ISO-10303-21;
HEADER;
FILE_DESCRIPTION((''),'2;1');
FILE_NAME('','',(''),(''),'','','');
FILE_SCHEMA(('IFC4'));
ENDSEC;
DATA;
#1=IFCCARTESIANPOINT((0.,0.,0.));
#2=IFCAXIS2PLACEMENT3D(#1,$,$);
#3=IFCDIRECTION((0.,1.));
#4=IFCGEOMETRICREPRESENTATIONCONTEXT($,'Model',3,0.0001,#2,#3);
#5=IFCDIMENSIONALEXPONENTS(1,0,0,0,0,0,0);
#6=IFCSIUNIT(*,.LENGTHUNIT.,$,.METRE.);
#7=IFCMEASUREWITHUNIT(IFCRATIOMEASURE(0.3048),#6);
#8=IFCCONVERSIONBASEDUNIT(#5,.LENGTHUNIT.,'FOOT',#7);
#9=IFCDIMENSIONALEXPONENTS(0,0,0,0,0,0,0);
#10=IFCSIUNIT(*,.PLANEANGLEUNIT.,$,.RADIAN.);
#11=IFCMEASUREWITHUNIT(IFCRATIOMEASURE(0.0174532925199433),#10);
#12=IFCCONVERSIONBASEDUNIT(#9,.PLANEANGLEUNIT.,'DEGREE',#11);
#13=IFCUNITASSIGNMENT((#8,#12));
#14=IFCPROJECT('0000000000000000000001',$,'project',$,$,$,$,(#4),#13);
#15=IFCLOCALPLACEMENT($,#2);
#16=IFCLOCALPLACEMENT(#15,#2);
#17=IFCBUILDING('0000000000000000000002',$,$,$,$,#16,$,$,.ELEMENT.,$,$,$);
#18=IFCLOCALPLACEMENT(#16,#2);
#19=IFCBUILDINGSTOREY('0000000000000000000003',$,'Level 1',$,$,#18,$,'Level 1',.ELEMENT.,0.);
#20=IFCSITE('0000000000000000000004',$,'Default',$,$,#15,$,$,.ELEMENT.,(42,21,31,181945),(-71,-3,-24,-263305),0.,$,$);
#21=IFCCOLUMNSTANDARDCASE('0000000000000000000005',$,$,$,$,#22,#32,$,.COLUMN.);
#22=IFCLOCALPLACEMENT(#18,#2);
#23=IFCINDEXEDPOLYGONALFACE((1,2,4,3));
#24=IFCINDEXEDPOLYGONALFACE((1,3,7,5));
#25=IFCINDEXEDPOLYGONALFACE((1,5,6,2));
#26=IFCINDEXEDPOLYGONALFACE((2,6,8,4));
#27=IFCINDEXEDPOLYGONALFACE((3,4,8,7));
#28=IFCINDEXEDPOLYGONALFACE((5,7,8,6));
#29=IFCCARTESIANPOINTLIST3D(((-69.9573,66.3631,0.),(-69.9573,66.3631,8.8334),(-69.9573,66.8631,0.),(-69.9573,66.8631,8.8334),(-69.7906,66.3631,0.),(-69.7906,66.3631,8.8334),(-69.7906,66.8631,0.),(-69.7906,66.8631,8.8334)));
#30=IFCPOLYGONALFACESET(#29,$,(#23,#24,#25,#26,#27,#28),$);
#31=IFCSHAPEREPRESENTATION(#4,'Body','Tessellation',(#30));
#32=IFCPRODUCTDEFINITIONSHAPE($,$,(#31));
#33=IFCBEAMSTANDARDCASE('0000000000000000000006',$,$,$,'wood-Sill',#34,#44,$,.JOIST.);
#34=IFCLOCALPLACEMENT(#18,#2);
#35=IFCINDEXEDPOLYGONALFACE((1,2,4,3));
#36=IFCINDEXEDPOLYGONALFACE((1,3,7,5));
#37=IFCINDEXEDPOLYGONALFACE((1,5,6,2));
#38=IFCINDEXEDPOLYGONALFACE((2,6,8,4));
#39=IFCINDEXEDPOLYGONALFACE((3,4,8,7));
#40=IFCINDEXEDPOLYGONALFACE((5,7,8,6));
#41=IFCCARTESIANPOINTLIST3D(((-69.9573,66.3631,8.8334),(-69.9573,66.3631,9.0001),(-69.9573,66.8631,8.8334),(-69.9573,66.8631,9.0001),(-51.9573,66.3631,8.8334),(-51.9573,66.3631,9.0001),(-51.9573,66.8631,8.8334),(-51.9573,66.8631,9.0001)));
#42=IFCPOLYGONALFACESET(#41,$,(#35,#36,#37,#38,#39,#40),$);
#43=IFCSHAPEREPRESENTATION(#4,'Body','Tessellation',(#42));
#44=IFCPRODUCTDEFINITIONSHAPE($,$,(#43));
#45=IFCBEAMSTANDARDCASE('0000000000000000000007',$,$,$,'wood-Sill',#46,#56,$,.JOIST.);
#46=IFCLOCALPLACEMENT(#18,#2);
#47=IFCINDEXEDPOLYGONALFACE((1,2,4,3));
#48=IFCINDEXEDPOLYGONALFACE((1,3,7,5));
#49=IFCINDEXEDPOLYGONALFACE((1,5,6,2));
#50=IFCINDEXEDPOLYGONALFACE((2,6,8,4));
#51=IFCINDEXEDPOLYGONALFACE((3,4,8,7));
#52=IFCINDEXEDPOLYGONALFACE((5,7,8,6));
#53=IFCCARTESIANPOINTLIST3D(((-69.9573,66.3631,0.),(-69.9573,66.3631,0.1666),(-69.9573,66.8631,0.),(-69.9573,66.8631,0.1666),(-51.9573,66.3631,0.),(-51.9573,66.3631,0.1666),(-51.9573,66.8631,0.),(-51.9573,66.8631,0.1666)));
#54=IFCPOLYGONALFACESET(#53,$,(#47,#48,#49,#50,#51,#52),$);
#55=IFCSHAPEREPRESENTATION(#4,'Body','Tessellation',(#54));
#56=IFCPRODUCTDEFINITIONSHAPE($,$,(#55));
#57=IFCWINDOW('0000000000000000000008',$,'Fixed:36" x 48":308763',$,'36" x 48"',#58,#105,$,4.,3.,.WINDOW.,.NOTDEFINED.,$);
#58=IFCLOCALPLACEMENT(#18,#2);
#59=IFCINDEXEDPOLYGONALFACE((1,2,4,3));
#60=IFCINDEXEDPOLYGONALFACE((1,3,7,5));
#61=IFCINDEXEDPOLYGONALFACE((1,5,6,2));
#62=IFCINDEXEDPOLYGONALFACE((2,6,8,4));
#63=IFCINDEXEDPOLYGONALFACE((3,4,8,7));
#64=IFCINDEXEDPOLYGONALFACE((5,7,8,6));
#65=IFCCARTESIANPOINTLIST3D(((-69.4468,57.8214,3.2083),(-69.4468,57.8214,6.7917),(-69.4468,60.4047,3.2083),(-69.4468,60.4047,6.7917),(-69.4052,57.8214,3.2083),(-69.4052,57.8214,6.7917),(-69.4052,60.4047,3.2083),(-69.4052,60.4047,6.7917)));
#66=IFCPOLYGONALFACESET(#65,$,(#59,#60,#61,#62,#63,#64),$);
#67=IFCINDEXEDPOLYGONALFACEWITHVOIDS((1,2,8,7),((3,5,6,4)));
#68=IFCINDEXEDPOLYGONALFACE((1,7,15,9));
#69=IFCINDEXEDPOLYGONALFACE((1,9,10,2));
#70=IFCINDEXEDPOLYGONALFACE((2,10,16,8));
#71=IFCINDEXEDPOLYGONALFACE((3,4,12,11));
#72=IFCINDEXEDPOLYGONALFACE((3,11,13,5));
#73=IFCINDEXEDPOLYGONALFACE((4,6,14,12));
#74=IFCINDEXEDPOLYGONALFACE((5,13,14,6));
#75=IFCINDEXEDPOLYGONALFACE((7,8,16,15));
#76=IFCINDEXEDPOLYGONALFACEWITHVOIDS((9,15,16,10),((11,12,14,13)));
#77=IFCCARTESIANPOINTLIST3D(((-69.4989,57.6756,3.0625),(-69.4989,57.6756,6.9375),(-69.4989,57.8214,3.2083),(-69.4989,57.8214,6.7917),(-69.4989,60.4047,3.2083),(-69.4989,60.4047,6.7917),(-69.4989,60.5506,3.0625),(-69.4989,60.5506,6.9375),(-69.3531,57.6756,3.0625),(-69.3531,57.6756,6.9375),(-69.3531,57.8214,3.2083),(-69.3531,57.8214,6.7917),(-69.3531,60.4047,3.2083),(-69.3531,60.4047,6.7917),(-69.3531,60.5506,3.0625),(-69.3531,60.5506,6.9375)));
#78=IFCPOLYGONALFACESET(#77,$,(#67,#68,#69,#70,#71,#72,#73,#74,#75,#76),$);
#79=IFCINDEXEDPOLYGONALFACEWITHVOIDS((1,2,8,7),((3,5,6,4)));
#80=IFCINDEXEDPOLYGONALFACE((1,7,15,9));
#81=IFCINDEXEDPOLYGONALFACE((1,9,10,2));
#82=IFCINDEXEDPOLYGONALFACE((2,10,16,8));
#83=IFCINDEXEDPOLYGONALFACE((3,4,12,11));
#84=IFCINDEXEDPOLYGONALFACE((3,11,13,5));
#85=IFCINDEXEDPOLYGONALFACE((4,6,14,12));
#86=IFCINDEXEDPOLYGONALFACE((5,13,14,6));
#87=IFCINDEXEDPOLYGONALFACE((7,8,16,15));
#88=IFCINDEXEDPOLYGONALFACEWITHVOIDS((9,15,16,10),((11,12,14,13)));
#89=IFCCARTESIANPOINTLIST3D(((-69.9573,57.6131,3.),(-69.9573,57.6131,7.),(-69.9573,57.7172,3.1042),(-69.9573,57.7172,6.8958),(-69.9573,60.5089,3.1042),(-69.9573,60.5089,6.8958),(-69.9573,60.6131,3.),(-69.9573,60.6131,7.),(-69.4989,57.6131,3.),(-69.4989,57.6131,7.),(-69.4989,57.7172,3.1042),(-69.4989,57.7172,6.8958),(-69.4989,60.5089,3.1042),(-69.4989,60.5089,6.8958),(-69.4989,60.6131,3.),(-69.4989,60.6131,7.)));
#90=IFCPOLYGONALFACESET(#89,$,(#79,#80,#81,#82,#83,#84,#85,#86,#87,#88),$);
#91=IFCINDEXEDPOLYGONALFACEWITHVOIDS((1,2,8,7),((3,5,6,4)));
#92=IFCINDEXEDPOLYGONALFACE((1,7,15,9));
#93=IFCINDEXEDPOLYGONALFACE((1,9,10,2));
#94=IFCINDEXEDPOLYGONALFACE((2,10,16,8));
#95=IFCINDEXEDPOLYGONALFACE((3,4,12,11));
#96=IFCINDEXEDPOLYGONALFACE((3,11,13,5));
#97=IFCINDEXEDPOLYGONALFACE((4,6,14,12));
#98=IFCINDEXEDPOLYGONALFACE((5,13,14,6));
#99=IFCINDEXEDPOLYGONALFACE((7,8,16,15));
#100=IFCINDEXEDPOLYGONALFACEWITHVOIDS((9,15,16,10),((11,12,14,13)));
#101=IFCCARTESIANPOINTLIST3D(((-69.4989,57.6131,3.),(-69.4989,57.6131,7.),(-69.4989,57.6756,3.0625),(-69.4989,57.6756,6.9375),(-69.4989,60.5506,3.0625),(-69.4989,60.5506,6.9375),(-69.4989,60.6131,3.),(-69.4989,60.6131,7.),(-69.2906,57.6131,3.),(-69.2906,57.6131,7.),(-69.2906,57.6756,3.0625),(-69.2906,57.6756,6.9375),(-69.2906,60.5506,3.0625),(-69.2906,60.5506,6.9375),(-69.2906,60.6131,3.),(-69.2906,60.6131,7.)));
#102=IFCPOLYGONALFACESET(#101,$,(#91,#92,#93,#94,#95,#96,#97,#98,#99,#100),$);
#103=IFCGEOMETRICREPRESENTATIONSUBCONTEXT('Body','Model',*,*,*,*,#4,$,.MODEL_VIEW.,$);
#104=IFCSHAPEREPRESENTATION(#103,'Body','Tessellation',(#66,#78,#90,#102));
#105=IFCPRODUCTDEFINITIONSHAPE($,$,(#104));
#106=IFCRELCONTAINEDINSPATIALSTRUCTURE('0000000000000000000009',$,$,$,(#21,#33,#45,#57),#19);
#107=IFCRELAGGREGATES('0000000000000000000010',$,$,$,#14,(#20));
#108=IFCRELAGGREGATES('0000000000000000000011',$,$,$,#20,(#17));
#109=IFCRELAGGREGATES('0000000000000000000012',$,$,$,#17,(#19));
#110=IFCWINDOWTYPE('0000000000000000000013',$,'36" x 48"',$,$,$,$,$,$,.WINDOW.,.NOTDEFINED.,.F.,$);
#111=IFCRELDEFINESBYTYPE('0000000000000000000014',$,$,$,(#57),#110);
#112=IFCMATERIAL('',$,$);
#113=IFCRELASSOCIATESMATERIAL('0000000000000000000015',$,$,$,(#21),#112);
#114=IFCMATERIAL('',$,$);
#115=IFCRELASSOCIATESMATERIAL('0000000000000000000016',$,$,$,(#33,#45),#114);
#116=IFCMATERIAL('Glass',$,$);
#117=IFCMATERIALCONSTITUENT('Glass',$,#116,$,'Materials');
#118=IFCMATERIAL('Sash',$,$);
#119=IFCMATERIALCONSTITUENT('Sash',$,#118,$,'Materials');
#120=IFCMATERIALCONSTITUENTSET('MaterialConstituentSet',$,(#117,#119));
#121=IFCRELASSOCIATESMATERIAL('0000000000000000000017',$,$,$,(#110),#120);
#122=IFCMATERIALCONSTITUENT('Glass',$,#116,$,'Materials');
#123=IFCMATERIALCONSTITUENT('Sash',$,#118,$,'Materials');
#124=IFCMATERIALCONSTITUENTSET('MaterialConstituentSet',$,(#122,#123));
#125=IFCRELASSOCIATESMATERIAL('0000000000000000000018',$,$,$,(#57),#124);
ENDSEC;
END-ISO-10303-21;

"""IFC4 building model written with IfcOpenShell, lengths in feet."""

from ifc_helpers import new_model, entity, si_unit, converted_unit, direction, frame, frame_2d, origin, origin_with_axes, place, context, subcontext, project, spatial, polyline, rectangle, outline, extrude, source, transform, mapped, material, constituent, constituent_set, type_object, type_shapes, element, save


model = new_model("IFC4")

# Units and contexts
model_context = context("Model", 3, precision=0.0001, world=origin(), true_north=direction((0.0, 1.0)))
body_context = subcontext(model_context, "Body", "Model", "MODEL_VIEW")
ifc_project = project(units=[converted_unit("LENGTHUNIT", "FOOT", entity("IfcRatioMeasure", 0.3048), si_unit("LENGTHUNIT", "METRE"), dimensions=[1, 0, 0, 0, 0, 0, 0]), converted_unit("PLANEANGLEUNIT", "DEGREE", entity("IfcRatioMeasure", 0.0174532925199433), si_unit("PLANEANGLEUNIT", "RADIAN"), dimensions=[0, 0, 0, 0, 0, 0, 0])], contexts=[model_context])

# Site, building, storey
site_placement = place(None, origin())
site = spatial("IfcSite", under=ifc_project, at=site_placement, Name="Default", CompositionType="ELEMENT", RefLatitude=(42, 21, 31, 181945), RefLongitude=(-71, -3, -24, -263305), RefElevation=0.0)
building_placement = place(site_placement, origin())
building = spatial("IfcBuilding", under=site, at=building_placement, CompositionType="ELEMENT")
storey_placement = place(building_placement, origin())
storey = spatial("IfcBuildingStorey", under=building, at=storey_placement, Name="Level 1", LongName="Level 1", CompositionType="ELEMENT", Elevation=0.0)

# Column
ifc_material_1 = material(Name="")
placement_1 = place(storey_placement, frame((-69.9573, 66.6131, 0.0)))
for number, where, z_axis, x_axis in (
    (1, (0.0833, 0.0, 0.0), (0.0, 0.0, 1.0), (1.0, 0.0, 0.0)),
):
    element("IfcColumnStandardCase", number, at=place(placement_1, frame(where, z_axis=z_axis, x_axis=x_axis)), inside=storey, material=ifc_material_1, PredefinedType="COLUMN", context=model_context, shape_type="SweptSolid", body=[
        extrude(rectangle(XDim=0.1667, YDim=0.5), origin(), (0.0, 0.0, 1.0), 8.8334),
    ])
placement_2 = place(storey_placement, frame((-69.6239, 19.7797, 0.0), z_axis=(0.0, 0.0, 1.0), x_axis=(0.0, 1.0, 0.0)))

# Beams
ifc_material_2 = material(Name="")
for number, where, z_axis, x_axis in (
    (2, (0.0, 0.0, 8.9167), (1.0, 0.0, 0.0), (0.0, 0.0, 1.0)),
    (3, (0.0, 0.0, 0.0833), (1.0, 0.0, 0.0), (0.0, 0.0, 1.0)),
):
    element("IfcBeamStandardCase", number, at=place(placement_1, frame(where, z_axis=z_axis, x_axis=x_axis)), inside=storey, material=ifc_material_2, ObjectType="wood-Sill", PredefinedType="JOIST", context=model_context, shape_type="SweptSolid", body=[
        extrude(rectangle(XDim=0.1667, YDim=0.5), origin_with_axes(), (0.0, 0.0, 1.0), 18.0),
    ])

# Window
ifc_material_3 = material(Name="Glass")
ifc_constituent_1 = constituent(ifc_material_3, Name="Glass", Category="Materials")
ifc_material_4 = material(Name="Sash")
ifc_constituent_2 = constituent(ifc_material_4, Name="Sash", Category="Materials")
ifc_constituent_set_1 = constituent_set(constituents=[ifc_constituent_1, ifc_constituent_2], Name="MaterialConstituentSet")
ifc_constituent_3 = constituent(ifc_material_3, Name="Glass", Category="Materials")
ifc_constituent_4 = constituent(ifc_material_4, Name="Sash", Category="Materials")
ifc_constituent_set_2 = constituent_set(constituents=[ifc_constituent_3, ifc_constituent_4], Name="MaterialConstituentSet")
window_type = type_object("IfcWindowType", Name="36\" x 48\"", ParameterTakesPrecedence=False, PartitioningType="NOTDEFINED", PredefinedType="WINDOW", material=ifc_constituent_set_2)
shared_shape = source(origin(), body_context, "Body", "SweptSolid", [
    extrude(rectangle(XDim=0.0417, YDim=2.5833, at=frame_2d((0.0, 0.0), x_axis=(1.0, 0.0))), frame((1.5, 0.5312, 0.2083), z_axis=(0.0, 0.0, 1.0), x_axis=(0.0, 1.0, 0.0)), (0.0, 0.0, 1.0), 3.5833),
    extrude(outline(polyline([(-1.4375, -1.9375), (1.4375, -1.9375), (1.4375, 1.9375), (-1.4375, 1.9375), (-1.4375, -1.9375)]), holes=[polyline([(-1.2917, -1.7917), (-1.2917, 1.7917), (1.2917, 1.7917), (1.2917, -1.7917), (-1.2917, -1.7917)])]), frame((1.5, 0.4583, 2.0), z_axis=(0.0, 1.0, 0.0), x_axis=(1.0, 0.0, 0.0)), (0.0, 0.0, 1.0), 0.1458),
    extrude(outline(polyline([(-1.5, -2.0), (1.5, -2.0), (1.5, 2.0), (-1.5, 2.0), (-1.5, -2.0)]), holes=[polyline([(-1.3958, -1.8958), (-1.3958, 1.8958), (1.3958, 1.8958), (1.3958, -1.8958), (-1.3958, -1.8958)])]), frame((1.5, 0.0, 2.0), z_axis=(0.0, 1.0, 0.0), x_axis=(1.0, 0.0, 0.0)), (0.0, 0.0, 1.0), 0.4583),
    extrude(outline(polyline([(-2.0, -1.5), (2.0, -1.5), (2.0, 1.5), (-2.0, 1.5), (-2.0, -1.5)]), holes=[polyline([(-1.9375, -1.4375), (-1.9375, 1.4375), (1.9375, 1.4375), (1.9375, -1.4375), (-1.9375, -1.4375)])]), frame((1.5, 0.4583, 2.0), z_axis=(0.0, 1.0, 0.0), x_axis=(0.0, 0.0, -1.0)), (0.0, 0.0, 1.0), 0.2083),
])
type_shapes(window_type, [shared_shape])
placement_3 = place(placement_2, frame((40.8333, 0.3333, 3.0)))
window_placement = place(placement_3, frame((0.0, 0.0, 0.0), z_axis=(0.0, 0.0, 1.0), x_axis=(-1.0, 0.0, 0.0)))
element("IfcWindow", 4, at=window_placement, inside=storey, type_object=window_type, material=ifc_constituent_set_1, Name="Fixed:36\" x 48\":308763", ObjectType="36\" x 48\"", OverallHeight=4.0, OverallWidth=3.0, PartitioningType="NOTDEFINED", PredefinedType="WINDOW", context=body_context, shape_type="MappedRepresentation", body=[
    mapped(shared_shape, transform((0.0, 0.0, 0.0), scale=1.0)),
])

save(model, "model.ifc")
